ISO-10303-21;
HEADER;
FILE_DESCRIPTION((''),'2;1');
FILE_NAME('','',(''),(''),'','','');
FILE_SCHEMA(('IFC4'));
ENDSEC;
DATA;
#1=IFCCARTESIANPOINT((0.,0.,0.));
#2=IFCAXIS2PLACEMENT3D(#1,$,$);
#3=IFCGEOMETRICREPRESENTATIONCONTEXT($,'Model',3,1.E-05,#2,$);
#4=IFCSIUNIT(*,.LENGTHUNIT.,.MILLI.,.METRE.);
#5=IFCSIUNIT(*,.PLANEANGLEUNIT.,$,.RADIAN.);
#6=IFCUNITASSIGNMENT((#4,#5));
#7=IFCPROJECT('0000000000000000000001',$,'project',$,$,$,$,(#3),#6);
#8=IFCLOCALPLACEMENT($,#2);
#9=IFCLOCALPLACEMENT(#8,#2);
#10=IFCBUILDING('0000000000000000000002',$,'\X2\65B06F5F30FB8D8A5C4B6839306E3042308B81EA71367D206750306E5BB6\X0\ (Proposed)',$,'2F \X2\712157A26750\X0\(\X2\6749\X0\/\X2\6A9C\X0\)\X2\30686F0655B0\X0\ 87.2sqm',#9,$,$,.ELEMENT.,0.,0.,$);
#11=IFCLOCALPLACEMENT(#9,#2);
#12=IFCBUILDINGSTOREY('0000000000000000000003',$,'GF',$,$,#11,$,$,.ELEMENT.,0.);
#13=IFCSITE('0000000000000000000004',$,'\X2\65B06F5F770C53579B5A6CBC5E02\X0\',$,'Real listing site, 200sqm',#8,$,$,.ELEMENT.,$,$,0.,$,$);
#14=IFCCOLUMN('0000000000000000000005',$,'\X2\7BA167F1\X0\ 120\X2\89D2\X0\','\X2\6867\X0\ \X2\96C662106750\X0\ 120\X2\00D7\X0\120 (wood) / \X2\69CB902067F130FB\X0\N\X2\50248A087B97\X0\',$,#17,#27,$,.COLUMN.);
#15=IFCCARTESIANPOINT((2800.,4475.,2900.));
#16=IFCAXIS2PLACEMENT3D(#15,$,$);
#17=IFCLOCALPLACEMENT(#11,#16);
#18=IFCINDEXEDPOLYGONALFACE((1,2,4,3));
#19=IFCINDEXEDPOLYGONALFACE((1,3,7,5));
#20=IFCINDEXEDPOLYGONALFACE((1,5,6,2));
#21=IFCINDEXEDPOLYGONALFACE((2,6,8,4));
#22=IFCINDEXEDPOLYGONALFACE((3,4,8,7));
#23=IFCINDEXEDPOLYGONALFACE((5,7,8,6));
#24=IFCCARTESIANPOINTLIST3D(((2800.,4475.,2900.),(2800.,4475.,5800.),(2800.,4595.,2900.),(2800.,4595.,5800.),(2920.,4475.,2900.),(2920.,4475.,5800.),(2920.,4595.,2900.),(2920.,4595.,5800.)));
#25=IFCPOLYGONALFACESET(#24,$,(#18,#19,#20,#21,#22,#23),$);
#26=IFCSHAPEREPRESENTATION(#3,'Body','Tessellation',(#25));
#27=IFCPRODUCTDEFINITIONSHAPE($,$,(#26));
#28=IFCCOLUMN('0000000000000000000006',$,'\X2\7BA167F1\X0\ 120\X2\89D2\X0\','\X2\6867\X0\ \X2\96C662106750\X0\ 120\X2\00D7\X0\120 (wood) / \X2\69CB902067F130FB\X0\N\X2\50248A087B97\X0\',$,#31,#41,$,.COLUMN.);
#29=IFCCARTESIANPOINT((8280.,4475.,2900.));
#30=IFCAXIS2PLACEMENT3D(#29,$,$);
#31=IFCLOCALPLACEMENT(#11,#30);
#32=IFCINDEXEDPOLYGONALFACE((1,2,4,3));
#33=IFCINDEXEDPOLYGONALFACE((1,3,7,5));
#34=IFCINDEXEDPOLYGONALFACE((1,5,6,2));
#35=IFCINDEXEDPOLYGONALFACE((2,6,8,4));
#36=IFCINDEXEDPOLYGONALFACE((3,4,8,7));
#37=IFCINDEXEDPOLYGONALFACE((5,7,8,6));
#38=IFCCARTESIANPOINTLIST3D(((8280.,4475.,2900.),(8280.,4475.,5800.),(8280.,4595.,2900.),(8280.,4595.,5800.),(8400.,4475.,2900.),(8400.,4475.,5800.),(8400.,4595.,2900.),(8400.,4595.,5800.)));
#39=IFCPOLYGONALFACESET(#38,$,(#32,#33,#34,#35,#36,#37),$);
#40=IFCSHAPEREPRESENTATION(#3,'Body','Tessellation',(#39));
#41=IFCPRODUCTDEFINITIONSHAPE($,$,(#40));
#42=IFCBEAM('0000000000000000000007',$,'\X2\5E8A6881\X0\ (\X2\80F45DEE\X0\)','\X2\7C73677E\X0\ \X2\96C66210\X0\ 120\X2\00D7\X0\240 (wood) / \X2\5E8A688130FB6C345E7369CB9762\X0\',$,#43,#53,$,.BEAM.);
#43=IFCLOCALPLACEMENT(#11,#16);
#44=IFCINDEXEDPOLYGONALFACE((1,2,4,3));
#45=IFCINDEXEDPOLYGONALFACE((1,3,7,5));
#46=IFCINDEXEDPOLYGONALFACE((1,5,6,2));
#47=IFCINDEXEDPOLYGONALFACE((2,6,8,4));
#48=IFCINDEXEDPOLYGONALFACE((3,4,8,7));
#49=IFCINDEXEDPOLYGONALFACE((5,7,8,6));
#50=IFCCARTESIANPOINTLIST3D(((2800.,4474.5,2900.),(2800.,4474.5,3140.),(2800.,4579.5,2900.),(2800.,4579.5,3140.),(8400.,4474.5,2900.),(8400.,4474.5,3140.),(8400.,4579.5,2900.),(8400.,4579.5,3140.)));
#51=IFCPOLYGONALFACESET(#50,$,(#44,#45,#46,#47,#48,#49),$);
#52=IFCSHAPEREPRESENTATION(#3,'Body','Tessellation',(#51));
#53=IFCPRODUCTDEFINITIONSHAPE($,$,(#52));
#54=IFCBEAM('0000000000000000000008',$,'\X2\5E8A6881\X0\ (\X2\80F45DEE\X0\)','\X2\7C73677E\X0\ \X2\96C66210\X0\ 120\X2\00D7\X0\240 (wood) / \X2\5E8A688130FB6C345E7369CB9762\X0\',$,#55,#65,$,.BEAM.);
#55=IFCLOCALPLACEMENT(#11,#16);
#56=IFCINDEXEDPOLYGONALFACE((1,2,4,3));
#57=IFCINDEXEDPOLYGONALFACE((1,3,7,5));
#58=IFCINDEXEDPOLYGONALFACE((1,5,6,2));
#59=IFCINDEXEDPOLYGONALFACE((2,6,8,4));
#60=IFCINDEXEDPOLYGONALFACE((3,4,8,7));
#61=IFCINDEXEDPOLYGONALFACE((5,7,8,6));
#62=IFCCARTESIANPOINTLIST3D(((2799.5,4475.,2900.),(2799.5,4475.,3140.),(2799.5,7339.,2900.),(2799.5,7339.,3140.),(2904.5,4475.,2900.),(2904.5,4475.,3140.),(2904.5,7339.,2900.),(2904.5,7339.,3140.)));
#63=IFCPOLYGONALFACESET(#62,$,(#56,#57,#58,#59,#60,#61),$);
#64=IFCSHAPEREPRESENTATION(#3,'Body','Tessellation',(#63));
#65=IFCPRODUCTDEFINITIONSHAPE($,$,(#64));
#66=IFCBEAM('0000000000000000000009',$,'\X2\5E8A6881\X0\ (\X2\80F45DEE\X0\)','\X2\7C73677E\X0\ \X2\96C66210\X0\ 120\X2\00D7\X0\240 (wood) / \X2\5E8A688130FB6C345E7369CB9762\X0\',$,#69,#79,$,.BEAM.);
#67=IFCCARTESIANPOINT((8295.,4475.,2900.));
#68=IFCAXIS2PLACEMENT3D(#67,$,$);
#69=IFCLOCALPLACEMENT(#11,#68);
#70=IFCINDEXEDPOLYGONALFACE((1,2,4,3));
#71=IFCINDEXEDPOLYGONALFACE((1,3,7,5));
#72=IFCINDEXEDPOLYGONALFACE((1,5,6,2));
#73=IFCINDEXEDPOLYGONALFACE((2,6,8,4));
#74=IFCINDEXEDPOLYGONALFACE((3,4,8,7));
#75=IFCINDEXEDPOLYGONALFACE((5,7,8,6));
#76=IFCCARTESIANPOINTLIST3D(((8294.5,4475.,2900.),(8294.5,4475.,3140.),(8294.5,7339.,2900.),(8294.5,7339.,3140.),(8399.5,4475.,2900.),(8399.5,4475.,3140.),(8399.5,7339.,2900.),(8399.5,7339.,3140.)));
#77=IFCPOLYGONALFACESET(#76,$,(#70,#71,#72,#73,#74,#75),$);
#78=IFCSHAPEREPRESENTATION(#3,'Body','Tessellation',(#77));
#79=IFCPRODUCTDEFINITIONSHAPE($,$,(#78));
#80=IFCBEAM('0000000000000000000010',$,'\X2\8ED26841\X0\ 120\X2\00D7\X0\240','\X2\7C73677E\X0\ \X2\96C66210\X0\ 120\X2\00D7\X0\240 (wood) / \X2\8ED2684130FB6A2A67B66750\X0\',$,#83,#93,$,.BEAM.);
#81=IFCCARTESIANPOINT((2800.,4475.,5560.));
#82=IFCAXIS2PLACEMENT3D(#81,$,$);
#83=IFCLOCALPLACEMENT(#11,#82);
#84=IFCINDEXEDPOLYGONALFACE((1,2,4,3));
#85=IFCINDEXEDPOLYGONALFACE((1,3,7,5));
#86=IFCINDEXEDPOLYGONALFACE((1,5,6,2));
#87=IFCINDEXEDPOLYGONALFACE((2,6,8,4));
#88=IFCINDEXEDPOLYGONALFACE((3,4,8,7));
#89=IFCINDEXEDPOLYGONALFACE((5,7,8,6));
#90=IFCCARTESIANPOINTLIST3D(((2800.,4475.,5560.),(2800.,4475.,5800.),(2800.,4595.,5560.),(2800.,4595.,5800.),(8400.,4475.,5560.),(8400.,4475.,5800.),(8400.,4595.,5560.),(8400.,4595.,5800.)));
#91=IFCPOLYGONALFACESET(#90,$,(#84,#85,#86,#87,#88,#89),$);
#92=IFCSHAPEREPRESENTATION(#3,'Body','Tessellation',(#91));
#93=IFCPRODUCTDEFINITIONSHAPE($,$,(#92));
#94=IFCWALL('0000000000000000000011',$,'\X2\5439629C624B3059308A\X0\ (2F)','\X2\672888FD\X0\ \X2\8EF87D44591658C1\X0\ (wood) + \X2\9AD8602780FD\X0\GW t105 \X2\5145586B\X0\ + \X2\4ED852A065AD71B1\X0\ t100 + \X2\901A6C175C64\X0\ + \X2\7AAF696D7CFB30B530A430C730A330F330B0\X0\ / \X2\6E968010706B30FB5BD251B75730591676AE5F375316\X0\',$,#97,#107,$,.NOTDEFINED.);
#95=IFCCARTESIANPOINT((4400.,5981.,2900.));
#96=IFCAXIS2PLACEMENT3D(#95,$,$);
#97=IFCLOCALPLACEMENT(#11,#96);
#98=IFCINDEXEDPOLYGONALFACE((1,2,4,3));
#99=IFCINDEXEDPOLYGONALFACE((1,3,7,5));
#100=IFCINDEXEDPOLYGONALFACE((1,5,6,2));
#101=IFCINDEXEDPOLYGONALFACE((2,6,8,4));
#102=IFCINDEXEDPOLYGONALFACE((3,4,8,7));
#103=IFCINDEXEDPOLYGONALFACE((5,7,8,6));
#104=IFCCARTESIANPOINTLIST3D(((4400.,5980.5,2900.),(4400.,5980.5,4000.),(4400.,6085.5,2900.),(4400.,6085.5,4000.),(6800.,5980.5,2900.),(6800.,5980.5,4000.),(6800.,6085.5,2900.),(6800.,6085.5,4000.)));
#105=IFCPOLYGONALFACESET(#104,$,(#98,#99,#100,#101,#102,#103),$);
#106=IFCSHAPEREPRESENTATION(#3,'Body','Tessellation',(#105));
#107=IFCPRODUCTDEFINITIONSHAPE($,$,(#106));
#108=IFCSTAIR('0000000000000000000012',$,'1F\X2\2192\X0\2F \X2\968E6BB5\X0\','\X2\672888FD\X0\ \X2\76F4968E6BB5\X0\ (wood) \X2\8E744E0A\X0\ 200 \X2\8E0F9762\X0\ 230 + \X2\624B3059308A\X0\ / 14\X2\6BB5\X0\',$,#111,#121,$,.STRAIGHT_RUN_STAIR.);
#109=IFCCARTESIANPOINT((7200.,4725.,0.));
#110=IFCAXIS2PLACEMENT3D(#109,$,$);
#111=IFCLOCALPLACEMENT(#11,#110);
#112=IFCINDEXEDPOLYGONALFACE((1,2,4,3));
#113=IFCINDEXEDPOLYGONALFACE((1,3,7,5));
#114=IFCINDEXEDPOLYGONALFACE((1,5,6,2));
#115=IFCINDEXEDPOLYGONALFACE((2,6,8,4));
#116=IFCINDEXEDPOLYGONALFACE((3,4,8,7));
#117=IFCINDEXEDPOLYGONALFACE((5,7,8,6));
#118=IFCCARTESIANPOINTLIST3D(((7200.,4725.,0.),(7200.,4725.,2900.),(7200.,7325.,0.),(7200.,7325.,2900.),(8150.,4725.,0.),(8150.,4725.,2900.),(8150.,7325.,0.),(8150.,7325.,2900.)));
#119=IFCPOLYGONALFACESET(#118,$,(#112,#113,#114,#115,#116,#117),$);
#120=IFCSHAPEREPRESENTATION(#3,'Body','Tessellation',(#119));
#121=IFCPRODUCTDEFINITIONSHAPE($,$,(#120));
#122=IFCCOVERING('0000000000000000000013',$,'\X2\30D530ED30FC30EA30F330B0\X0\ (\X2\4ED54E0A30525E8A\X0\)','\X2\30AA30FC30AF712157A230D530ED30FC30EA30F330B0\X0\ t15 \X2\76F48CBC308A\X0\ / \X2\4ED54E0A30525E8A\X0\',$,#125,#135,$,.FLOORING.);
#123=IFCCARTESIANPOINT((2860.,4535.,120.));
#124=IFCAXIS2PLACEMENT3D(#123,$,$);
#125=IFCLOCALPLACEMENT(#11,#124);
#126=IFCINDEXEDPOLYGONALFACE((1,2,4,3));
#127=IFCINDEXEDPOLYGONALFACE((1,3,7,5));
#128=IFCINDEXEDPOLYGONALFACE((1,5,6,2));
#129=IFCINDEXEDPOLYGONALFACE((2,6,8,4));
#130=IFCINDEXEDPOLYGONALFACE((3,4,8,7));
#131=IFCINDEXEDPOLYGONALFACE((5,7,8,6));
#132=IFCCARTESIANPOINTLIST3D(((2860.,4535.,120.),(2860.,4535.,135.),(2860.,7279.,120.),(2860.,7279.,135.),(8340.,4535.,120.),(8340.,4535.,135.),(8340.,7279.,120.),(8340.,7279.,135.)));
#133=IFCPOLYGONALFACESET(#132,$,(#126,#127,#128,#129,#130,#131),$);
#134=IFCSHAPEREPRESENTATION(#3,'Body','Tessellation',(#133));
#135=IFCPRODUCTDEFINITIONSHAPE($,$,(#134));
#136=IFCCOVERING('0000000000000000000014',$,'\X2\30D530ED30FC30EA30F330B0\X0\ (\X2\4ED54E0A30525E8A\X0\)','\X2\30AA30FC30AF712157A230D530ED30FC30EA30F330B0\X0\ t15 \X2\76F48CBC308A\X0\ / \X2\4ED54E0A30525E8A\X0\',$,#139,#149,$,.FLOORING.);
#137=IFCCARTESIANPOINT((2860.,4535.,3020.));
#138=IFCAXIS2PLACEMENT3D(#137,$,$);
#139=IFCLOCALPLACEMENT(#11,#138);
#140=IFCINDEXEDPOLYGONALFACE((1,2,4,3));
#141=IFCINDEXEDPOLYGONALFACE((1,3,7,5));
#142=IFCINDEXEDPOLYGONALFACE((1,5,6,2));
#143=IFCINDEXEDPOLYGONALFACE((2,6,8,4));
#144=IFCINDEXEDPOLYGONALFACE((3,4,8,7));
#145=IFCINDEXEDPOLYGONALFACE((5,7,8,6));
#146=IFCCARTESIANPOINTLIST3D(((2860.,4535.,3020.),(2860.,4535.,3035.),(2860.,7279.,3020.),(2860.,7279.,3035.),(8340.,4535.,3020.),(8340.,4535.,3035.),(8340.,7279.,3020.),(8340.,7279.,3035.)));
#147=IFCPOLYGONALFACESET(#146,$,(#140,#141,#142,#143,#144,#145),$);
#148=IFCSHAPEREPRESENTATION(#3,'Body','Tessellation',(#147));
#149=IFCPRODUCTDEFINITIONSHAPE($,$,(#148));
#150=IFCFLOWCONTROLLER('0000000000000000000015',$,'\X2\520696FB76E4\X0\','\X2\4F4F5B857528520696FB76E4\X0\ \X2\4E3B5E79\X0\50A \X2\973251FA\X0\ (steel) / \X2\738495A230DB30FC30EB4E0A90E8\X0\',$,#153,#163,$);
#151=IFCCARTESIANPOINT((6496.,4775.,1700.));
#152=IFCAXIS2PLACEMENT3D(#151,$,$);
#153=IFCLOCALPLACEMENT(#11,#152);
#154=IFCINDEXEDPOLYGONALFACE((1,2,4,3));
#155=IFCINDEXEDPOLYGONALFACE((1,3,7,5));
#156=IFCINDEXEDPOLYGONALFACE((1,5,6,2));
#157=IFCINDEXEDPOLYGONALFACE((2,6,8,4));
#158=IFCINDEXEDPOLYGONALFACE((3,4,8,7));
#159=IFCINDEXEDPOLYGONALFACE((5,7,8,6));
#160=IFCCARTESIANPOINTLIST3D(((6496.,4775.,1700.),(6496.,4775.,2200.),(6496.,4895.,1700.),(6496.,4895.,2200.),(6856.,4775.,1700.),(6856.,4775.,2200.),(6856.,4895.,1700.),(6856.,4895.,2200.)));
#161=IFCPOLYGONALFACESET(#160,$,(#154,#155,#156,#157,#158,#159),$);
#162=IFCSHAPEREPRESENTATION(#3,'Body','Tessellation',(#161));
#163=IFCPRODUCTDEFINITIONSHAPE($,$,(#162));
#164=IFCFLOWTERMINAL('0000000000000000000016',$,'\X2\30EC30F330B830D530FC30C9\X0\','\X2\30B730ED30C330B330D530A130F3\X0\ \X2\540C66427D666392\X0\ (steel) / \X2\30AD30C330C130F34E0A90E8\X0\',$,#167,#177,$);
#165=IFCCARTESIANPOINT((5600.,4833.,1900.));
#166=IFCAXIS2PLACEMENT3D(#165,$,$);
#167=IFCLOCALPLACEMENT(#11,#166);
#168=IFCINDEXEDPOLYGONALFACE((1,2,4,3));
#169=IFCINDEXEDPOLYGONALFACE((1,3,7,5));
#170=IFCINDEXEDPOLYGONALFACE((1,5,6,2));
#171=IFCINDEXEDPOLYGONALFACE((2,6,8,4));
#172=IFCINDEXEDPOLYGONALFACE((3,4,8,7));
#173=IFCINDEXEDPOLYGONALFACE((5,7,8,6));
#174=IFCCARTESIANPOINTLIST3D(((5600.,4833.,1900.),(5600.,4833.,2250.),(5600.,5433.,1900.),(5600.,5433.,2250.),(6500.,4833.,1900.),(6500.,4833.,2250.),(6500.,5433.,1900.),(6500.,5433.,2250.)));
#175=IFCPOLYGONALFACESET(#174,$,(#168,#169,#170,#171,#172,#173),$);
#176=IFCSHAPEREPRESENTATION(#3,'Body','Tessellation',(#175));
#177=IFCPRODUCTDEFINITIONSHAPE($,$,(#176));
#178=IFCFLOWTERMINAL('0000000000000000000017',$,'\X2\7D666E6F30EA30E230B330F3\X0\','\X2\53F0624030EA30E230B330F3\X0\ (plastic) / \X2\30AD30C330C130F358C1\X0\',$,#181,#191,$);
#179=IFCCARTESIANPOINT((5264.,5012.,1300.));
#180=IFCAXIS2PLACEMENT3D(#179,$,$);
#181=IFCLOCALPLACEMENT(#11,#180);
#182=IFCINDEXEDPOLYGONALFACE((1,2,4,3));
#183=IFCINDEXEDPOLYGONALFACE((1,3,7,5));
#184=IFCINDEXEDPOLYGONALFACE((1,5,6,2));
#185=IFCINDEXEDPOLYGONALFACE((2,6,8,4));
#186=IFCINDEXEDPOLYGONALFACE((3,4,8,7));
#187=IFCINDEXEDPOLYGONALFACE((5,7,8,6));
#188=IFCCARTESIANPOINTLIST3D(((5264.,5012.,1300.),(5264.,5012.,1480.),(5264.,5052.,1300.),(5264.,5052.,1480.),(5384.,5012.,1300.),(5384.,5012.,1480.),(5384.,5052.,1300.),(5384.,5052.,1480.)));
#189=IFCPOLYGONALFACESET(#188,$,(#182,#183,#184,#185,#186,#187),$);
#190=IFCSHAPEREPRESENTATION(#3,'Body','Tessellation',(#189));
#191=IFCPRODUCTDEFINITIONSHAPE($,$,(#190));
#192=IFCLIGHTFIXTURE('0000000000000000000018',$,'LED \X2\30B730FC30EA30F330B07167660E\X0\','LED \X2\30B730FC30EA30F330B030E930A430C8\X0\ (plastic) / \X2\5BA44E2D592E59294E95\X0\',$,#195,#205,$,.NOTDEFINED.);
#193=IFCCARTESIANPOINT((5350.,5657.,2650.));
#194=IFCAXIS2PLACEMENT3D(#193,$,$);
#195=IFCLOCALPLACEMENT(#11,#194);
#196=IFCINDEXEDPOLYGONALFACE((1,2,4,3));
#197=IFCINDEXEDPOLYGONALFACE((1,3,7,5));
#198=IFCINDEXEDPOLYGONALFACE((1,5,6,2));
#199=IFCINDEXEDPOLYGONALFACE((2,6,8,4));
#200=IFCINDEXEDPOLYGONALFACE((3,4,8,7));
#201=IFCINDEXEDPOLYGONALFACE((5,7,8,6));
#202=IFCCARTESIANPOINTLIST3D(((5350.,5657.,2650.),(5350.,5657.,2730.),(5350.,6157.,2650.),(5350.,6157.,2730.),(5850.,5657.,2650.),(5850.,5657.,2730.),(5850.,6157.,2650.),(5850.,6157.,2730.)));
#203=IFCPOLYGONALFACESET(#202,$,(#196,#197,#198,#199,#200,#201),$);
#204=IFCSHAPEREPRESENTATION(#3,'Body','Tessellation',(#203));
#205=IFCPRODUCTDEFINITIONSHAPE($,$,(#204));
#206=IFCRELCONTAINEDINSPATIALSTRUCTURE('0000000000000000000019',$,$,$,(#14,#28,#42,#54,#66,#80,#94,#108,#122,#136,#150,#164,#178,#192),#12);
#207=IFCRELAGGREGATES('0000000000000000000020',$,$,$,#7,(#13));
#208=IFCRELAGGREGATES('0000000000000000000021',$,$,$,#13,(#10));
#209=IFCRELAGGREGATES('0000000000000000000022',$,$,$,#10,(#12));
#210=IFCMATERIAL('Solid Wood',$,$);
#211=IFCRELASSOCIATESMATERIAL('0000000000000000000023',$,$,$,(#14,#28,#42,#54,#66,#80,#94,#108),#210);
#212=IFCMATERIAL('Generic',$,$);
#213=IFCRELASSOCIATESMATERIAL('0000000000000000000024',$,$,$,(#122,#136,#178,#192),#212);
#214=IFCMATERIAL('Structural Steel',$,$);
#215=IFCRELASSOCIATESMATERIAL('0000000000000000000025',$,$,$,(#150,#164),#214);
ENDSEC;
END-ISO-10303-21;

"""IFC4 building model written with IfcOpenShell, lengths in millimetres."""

from ifc_helpers import new_model, si_unit, frame, frame_2d, origin, place, context, project, spatial, rectangle, extrude, material, element, save


model = new_model("IFC4")

# Units and contexts
model_context = context("Model", 3, precision=1e-05, world=origin())
ifc_project = project(units=[si_unit("LENGTHUNIT", "METRE", prefix="MILLI"), si_unit("PLANEANGLEUNIT", "RADIAN")], contexts=[model_context])

# Site, building, storey
site_placement = place(None, origin())
site = spatial("IfcSite", under=ifc_project, at=site_placement, Name="新潟県南魚沼市", ObjectType="Real listing site, 200sqm", CompositionType="ELEMENT", RefElevation=0.0)
building_placement = place(site_placement, origin())
building = spatial("IfcBuilding", under=site, at=building_placement, Name="新潟・越屋根のある自然素材の家 (Proposed)", ObjectType="2F 無垢材(杉/檜)と漆喰 87.2sqm", CompositionType="ELEMENT", ElevationOfRefHeight=0.0, ElevationOfTerrain=0.0)
storey_placement = place(building_placement, origin())
storey = spatial("IfcBuildingStorey", under=building, at=storey_placement, Name="GF", CompositionType="ELEMENT", Elevation=0.0)

# Columns
ifc_material_1 = material(Name="Solid Wood")
column_1_placement = place(storey_placement, frame((2800.0, 4475.0, 2900.0)))
element("IfcColumn", 1, at=column_1_placement, inside=storey, material=ifc_material_1, Name="管柱 120角", Description="桧 集成材 120×120 (wood) / 構造柱・N値計算", PredefinedType="COLUMN", context=model_context, shape_type="SweptSolid", body=[
    extrude(rectangle(XDim=120.0, YDim=120.0, at=frame_2d((60.0, 60.0))), frame((2800.0, 4475.0, 2900.0)), (0.0, 0.0, 1.0), 2900.0),
])
column_2_placement = place(storey_placement, frame((8280.0, 4475.0, 2900.0)))
element("IfcColumn", 2, at=column_2_placement, inside=storey, material=ifc_material_1, Name="管柱 120角", Description="桧 集成材 120×120 (wood) / 構造柱・N値計算", PredefinedType="COLUMN", context=model_context, shape_type="SweptSolid", body=[
    extrude(rectangle(XDim=120.0, YDim=120.0, at=frame_2d((60.0, 60.0))), frame((8280.0, 4475.0, 2900.0)), (0.0, 0.0, 1.0), 2900.0),
])

# Beams
beam_1_placement = place(storey_placement, frame((2800.0, 4475.0, 2900.0)))
element("IfcBeam", 3, at=beam_1_placement, inside=storey, material=ifc_material_1, Name="床梁 (胴差)", Description="米松 集成 120×240 (wood) / 床梁・水平構面", PredefinedType="BEAM", context=model_context, shape_type="SweptSolid", body=[
    extrude(rectangle(XDim=5600.0, YDim=105.0, at=frame_2d((2800.0, 52.0))), frame((2800.0, 4475.0, 2900.0)), (0.0, 0.0, 1.0), 240.0),
])
beam_2_placement = place(storey_placement, frame((2800.0, 4475.0, 2900.0)))
element("IfcBeam", 4, at=beam_2_placement, inside=storey, material=ifc_material_1, Name="床梁 (胴差)", Description="米松 集成 120×240 (wood) / 床梁・水平構面", PredefinedType="BEAM", context=model_context, shape_type="SweptSolid", body=[
    extrude(rectangle(XDim=105.0, YDim=2864.0, at=frame_2d((52.0, 1432.0))), frame((2800.0, 4475.0, 2900.0)), (0.0, 0.0, 1.0), 240.0),
])
beam_3_placement = place(storey_placement, frame((8295.0, 4475.0, 2900.0)))
element("IfcBeam", 5, at=beam_3_placement, inside=storey, material=ifc_material_1, Name="床梁 (胴差)", Description="米松 集成 120×240 (wood) / 床梁・水平構面", PredefinedType="BEAM", context=model_context, shape_type="SweptSolid", body=[
    extrude(rectangle(XDim=105.0, YDim=2864.0, at=frame_2d((52.0, 1432.0))), frame((8295.0, 4475.0, 2900.0)), (0.0, 0.0, 1.0), 240.0),
])
beam_4_placement = place(storey_placement, frame((2800.0, 4475.0, 5560.0)))
element("IfcBeam", 6, at=beam_4_placement, inside=storey, material=ifc_material_1, Name="軒桁 120×240", Description="米松 集成 120×240 (wood) / 軒桁・横架材", PredefinedType="BEAM", context=model_context, shape_type="SweptSolid", body=[
    extrude(rectangle(XDim=5600.0, YDim=120.0, at=frame_2d((2800.0, 60.0))), frame((2800.0, 4475.0, 5560.0)), (0.0, 0.0, 1.0), 240.0),
])

# Wall
wall_1_placement = place(storey_placement, frame((4400.0, 5981.0, 2900.0)))
element("IfcWall", 7, at=wall_1_placement, inside=storey, material=ifc_material_1, Name="吹抜手すり (2F)", Description="木製 軸組外壁 (wood) + 高性能GW t105 充填 + 付加断熱 t100 + 通気層 + 窯業系サイディング / 準耐火・寒冷地外皮強化", PredefinedType="NOTDEFINED", context=model_context, shape_type="SweptSolid", body=[
    extrude(rectangle(XDim=2400.0, YDim=105.0, at=frame_2d((1200.0, 52.0))), frame((4400.0, 5981.0, 2900.0)), (0.0, 0.0, 1.0), 1100.0),
])

# Stair
stair_placement = place(storey_placement, frame((7200.0, 4725.0, 0.0)))
element("IfcStair", 8, at=stair_placement, inside=storey, material=ifc_material_1, Name="1F→2F 階段", Description="木製 直階段 (wood) 蹴上 200 踏面 230 + 手すり / 14段", PredefinedType="STRAIGHT_RUN_STAIR", context=model_context, shape_type="SweptSolid", body=[
    extrude(rectangle(XDim=950.0, YDim=2600.0, at=frame_2d((475.0, 1300.0))), frame((7200.0, 4725.0, 0.0)), (0.0, 0.0, 1.0), 2900.0),
])

# Coverings
ifc_material_2 = material(Name="Generic")
covering_1_placement = place(storey_placement, frame((2860.0, 4535.0, 120.0)))
element("IfcCovering", 9, at=covering_1_placement, inside=storey, material=ifc_material_2, Name="フローリング (仕上げ床)", Description="オーク無垢フローリング t15 直貼り / 仕上げ床", PredefinedType="FLOORING", context=model_context, shape_type="SweptSolid", body=[
    extrude(rectangle(XDim=5480.0, YDim=2744.0, at=frame_2d((2740.0, 1372.0))), frame((2860.0, 4535.0, 120.0)), (0.0, 0.0, 1.0), 15.0),
])
covering_2_placement = place(storey_placement, frame((2860.0, 4535.0, 3020.0)))
element("IfcCovering", 10, at=covering_2_placement, inside=storey, material=ifc_material_2, Name="フローリング (仕上げ床)", Description="オーク無垢フローリング t15 直貼り / 仕上げ床", PredefinedType="FLOORING", context=model_context, shape_type="SweptSolid", body=[
    extrude(rectangle(XDim=5480.0, YDim=2744.0, at=frame_2d((2740.0, 1372.0))), frame((2860.0, 4535.0, 3020.0)), (0.0, 0.0, 1.0), 15.0),
])

# Flow controller
ifc_material_3 = material(Name="Structural Steel")
flow_controller_placement = place(storey_placement, frame((6496.0, 4775.0, 1700.0)))
element("IfcFlowController", 11, at=flow_controller_placement, inside=storey, material=ifc_material_3, Name="分電盤", Description="住宅用分電盤 主幹50A 露出 (steel) / 玄関ホール上部", context=model_context, shape_type="SweptSolid", body=[
    extrude(rectangle(XDim=360.0, YDim=120.0, at=frame_2d((180.0, 60.0))), frame((6496.0, 4775.0, 1700.0)), (0.0, 0.0, 1.0), 500.0),
])

# Flow terminals
flow_terminal_1_placement = place(storey_placement, frame((5600.0, 4833.0, 1900.0)))
element("IfcFlowTerminal", 12, at=flow_terminal_1_placement, inside=storey, material=ifc_material_3, Name="レンジフード", Description="シロッコファン 同時給排 (steel) / キッチン上部", context=model_context, shape_type="SweptSolid", body=[
    extrude(rectangle(XDim=900.0, YDim=600.0, at=frame_2d((450.0, 300.0))), frame((5600.0, 4833.0, 1900.0)), (0.0, 0.0, 1.0), 350.0),
])
flow_terminal_2_placement = place(storey_placement, frame((5264.0, 5012.0, 1300.0)))
element("IfcFlowTerminal", 13, at=flow_terminal_2_placement, inside=storey, material=ifc_material_2, Name="給湯リモコン", Description="台所リモコン (plastic) / キッチン壁", context=model_context, shape_type="SweptSolid", body=[
    extrude(rectangle(XDim=120.0, YDim=40.0, at=frame_2d((60.0, 20.0))), frame((5264.0, 5012.0, 1300.0)), (0.0, 0.0, 1.0), 180.0),
])

# Light fixture
light_fixture_1_placement = place(storey_placement, frame((5350.0, 5657.0, 2650.0)))
element("IfcLightFixture", 14, at=light_fixture_1_placement, inside=storey, material=ifc_material_2, Name="LED シーリング照明", Description="LED シーリングライト (plastic) / 室中央天井", PredefinedType="NOTDEFINED", context=model_context, shape_type="SweptSolid", body=[
    extrude(rectangle(XDim=500.0, YDim=500.0, at=frame_2d((250.0, 250.0))), frame((5350.0, 5657.0, 2650.0)), (0.0, 0.0, 1.0), 80.0),
])

save(model, "model.ifc")
